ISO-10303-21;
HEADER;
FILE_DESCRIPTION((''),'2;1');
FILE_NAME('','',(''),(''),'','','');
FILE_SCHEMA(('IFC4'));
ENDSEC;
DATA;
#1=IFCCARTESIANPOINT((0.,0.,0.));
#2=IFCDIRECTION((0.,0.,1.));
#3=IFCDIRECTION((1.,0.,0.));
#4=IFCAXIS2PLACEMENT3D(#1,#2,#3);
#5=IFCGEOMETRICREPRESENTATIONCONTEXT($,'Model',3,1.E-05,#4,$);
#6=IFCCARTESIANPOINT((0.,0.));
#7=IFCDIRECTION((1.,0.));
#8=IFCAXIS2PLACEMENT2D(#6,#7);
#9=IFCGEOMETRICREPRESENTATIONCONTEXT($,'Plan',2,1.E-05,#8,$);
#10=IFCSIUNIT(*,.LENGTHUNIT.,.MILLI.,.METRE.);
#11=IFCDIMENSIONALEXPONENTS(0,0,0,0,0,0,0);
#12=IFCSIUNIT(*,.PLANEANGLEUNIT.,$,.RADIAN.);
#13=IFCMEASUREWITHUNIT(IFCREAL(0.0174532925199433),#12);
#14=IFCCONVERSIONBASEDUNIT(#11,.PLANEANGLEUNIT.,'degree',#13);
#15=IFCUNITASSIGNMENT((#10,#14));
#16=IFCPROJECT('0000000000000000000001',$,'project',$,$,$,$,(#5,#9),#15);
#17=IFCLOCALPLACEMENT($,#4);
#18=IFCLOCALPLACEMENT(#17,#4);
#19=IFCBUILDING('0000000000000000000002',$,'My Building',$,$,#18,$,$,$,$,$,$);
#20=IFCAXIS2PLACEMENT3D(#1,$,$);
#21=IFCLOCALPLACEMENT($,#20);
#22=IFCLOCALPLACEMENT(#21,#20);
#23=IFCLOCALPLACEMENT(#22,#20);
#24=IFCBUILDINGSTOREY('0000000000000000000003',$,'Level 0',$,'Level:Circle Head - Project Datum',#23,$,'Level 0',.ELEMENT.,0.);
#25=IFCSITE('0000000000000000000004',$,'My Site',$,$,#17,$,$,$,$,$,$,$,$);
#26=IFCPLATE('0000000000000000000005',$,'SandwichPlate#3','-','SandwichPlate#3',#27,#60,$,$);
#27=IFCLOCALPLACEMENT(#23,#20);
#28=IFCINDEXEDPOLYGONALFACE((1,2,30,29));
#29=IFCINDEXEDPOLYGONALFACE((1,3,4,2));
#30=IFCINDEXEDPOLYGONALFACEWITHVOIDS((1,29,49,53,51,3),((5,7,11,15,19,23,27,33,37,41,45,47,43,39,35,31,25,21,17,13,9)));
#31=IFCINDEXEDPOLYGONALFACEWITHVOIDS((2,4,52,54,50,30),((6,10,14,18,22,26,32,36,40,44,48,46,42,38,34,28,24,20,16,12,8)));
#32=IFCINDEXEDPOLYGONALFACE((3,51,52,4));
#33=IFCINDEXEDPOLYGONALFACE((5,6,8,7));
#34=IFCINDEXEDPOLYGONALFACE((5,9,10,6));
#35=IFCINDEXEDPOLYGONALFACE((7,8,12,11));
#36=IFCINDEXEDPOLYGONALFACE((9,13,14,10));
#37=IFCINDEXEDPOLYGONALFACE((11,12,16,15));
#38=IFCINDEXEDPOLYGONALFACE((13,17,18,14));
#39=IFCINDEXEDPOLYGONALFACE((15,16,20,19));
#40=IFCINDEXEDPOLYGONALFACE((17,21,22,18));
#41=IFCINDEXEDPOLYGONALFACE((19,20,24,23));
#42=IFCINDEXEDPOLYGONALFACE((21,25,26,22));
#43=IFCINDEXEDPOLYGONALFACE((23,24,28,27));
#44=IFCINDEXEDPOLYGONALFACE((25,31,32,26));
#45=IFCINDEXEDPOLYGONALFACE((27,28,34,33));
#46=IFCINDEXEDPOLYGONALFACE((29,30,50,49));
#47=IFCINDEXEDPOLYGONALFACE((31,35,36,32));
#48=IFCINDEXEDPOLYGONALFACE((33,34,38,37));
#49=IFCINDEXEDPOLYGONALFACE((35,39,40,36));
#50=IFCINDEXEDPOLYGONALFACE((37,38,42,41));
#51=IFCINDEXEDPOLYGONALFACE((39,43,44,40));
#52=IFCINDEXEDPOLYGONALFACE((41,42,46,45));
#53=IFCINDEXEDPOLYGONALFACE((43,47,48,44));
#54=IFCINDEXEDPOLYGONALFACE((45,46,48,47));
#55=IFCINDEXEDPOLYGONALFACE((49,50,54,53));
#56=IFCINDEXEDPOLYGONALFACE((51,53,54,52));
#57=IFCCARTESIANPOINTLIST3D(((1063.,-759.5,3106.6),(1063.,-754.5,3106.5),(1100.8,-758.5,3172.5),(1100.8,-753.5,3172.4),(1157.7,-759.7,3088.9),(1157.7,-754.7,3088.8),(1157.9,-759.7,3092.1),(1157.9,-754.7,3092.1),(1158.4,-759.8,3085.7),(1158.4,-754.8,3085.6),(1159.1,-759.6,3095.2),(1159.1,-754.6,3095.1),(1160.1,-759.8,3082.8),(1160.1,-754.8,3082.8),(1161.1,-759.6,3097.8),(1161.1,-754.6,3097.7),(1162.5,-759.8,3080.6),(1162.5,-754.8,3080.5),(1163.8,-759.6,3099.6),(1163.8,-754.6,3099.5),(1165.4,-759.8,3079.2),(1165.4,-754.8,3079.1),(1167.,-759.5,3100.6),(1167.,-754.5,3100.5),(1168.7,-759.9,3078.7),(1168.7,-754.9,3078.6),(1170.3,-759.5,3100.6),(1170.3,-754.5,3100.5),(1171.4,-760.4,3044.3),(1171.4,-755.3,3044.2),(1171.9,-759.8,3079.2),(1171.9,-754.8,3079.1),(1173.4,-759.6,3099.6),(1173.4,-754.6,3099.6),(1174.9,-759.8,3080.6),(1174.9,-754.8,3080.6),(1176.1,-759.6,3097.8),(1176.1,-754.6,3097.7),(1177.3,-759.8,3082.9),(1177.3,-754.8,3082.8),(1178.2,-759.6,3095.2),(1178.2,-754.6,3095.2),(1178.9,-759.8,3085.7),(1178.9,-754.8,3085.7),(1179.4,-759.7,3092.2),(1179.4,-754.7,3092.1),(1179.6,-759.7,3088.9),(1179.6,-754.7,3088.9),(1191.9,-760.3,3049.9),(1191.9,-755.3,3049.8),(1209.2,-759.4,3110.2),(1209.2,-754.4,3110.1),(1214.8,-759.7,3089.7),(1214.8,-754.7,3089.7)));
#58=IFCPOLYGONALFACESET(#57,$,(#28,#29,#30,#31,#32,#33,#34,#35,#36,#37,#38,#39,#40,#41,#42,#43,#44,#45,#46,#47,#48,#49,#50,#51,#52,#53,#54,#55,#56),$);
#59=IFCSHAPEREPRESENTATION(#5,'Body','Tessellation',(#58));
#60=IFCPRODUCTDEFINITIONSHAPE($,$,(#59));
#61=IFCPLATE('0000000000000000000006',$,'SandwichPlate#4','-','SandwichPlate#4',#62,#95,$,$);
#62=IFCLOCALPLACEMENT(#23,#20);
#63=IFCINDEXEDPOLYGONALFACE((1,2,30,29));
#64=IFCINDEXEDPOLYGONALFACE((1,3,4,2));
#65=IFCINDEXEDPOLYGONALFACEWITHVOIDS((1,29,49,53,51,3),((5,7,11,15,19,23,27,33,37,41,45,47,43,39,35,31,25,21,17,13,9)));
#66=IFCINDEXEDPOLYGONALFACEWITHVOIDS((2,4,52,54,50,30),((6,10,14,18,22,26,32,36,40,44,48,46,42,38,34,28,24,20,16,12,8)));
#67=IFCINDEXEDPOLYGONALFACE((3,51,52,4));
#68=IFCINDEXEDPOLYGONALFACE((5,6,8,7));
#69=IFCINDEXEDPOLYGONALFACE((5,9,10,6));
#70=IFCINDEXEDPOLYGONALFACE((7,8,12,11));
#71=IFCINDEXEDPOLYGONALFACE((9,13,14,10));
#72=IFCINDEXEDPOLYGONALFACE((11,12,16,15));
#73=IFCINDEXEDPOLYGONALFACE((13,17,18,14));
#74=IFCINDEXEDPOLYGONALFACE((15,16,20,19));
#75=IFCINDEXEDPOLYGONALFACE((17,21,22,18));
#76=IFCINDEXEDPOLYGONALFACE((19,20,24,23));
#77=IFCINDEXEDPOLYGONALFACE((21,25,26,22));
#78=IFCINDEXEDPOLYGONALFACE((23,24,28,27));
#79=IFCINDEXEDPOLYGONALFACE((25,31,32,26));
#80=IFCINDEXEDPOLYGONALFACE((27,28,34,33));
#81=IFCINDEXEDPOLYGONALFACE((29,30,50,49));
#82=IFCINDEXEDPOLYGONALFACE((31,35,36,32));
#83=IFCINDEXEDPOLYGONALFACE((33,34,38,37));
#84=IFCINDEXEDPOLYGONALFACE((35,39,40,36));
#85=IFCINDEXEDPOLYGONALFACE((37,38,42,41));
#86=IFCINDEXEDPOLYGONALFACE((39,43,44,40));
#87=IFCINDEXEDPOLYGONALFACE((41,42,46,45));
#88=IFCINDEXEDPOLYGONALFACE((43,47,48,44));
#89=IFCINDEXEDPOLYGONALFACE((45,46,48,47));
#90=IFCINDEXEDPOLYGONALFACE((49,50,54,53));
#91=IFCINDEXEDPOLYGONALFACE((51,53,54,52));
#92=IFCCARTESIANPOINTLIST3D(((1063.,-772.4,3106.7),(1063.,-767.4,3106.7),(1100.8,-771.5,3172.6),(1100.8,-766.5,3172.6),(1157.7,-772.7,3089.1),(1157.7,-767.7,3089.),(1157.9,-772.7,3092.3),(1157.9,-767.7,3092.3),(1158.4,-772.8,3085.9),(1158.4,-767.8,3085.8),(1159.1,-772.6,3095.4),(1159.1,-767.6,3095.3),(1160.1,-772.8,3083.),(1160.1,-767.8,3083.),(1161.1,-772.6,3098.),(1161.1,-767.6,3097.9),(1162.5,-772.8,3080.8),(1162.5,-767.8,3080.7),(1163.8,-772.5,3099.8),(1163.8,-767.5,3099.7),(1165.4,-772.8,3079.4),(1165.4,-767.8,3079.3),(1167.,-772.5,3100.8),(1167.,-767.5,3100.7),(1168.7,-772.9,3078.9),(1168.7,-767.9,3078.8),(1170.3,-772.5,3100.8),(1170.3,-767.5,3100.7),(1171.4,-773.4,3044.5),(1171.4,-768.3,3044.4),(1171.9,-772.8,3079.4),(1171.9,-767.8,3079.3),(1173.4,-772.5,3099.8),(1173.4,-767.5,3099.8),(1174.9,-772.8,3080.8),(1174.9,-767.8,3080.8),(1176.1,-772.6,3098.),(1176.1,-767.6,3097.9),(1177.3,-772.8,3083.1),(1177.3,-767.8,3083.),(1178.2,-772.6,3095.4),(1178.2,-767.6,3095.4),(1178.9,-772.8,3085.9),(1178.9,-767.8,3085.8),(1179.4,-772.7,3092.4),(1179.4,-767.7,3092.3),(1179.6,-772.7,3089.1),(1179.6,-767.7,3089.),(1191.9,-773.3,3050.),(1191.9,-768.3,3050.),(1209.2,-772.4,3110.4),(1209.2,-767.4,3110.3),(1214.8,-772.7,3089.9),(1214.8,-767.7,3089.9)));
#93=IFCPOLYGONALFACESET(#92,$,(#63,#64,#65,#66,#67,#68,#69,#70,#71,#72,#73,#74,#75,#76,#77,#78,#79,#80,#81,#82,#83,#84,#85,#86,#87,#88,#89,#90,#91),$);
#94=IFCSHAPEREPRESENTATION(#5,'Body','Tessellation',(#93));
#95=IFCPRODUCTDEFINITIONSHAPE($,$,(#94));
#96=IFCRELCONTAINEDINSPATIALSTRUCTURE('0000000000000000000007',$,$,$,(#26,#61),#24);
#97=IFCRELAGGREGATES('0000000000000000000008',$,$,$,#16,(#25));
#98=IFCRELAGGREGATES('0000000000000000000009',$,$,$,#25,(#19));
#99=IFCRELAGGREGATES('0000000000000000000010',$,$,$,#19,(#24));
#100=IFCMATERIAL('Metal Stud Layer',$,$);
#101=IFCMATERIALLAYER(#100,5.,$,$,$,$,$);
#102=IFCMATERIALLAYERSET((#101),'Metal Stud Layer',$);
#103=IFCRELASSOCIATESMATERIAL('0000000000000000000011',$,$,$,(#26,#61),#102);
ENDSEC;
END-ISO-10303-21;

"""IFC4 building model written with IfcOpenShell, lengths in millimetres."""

from ifc_helpers import new_model, entity, si_unit, converted_unit, frame, origin, origin_with_axes, origin_2d_with_axis, place, context, project, spatial, polyline, circle, outline, extrude, material, layer, layer_set, element, save


model = new_model("IFC4")

# Units and contexts
model_context = context("Model", 3, precision=1e-05, world=origin_with_axes())
plan_context = context("Plan", 2, precision=1e-05, world=origin_2d_with_axis())
ifc_project = project(units=[si_unit("LENGTHUNIT", "METRE", prefix="MILLI"), converted_unit("PLANEANGLEUNIT", "degree", entity("IfcReal", 0.0174532925199433), si_unit("PLANEANGLEUNIT", "RADIAN"), dimensions=[0, 0, 0, 0, 0, 0, 0])], contexts=[model_context, plan_context])

# Site, building, storey
site_placement = place(None, origin_with_axes())
site = spatial("IfcSite", under=ifc_project, at=site_placement, Name="My Site")
building_placement = place(site_placement, origin_with_axes())
building = spatial("IfcBuilding", under=site, at=building_placement, Name="My Building")
placement_1 = place(None, origin())
placement_2 = place(placement_1, origin())
storey_placement = place(placement_2, origin())
storey = spatial("IfcBuildingStorey", under=building, at=storey_placement, Name="Level 0", ObjectType="Level:Circle Head - Project Datum", LongName="Level 0", CompositionType="ELEMENT", Elevation=0.0)

# Plates, openings
ifc_material = material(Name="Metal Stud Layer")
ifc_layer_1 = layer(ifc_material, 5.0)
ifc_layer_set_1 = layer_set([ifc_layer_1], Name="Metal Stud Layer")
plate_1_placement = place(storey_placement, frame((1184.4, -755.5, 3036.8), z_axis=(0.0, -0.999896, 0.014432), x_axis=(0.497964, 0.012516, 0.867107)))
plate_1 = element("IfcPlate", 1, at=plate_1_placement, inside=storey, material=ifc_layer_set_1, Name="SandwichPlate#3", Description="-", ObjectType="SandwichPlate#3", context=model_context, shape_type="SweptSolid", body=[
    extrude(outline(polyline([(0.0, 0.0), (76.0, 0.0), (76.0, 140.0), (0.0, 140.0), (0.0, 0.0)])), origin_with_axes(), (0.0, 0.0, 1.0), 5.0),
])
opening_1_placement = place(plate_1_placement, frame((38.0, 40.0, -0.5), z_axis=(0.0, 0.0, 1.0), x_axis=(0.0, 1.0, 0.0)))
element("IfcOpeningElement", 2, at=opening_1_placement, cuts=plate_1, ObjectType="Opening", context=model_context, shape_type="SweptSolid", body=[
    extrude(circle(Radius=11.0, at=origin_2d_with_axis()), origin(), (0.0, 0.0, 1.0), 6.0),
])
opening_2_placement = place(plate_1_placement, frame((0.0, 0.0, 0.0), z_axis=(0.0, 0.0, 1.0), x_axis=(1.0, 0.0, 0.0)))
element("IfcOpeningElement", 3, at=opening_2_placement, cuts=plate_1, ObjectType="Opening", context=model_context, shape_type="SweptSolid", body=[
    extrude(outline(polyline([(0.0, 0.0), (15.0, 0.0), (0.0, 15.0), (0.0, 0.0)])), origin(), (0.0, 0.0, 1.0), 5.0),
])
opening_3_placement = place(plate_1_placement, frame((0.0, 0.0, 0.0), z_axis=(0.0, 0.0, 1.0), x_axis=(1.0, 0.0, 0.0)))
element("IfcOpeningElement", 4, at=opening_3_placement, cuts=plate_1, ObjectType="Opening", context=model_context, shape_type="SweptSolid", body=[
    extrude(outline(polyline([(76.0, 0.0), (76.0, 15.0), (61.0, 0.0), (76.0, 0.0)])), origin(), (0.0, 0.0, 1.0), 5.0),
])
plate_2_placement = place(storey_placement, frame((1184.4, -768.5, 3037.0), z_axis=(0.0, -0.999896, 0.014432), x_axis=(0.497964, 0.012516, 0.867107)))
plate_2 = element("IfcPlate", 5, at=plate_2_placement, inside=storey, material=ifc_layer_set_1, Name="SandwichPlate#4", Description="-", ObjectType="SandwichPlate#4", context=model_context, shape_type="SweptSolid", body=[
    extrude(outline(polyline([(0.0, 0.0), (76.0, 0.0), (76.0, 140.0), (0.0, 140.0), (0.0, 0.0)])), origin_with_axes(), (0.0, 0.0, 1.0), 5.0),
])
opening_4_placement = place(plate_2_placement, frame((38.0, 40.0, -0.5), z_axis=(0.0, 0.0, 1.0), x_axis=(0.0, 1.0, 0.0)))
element("IfcOpeningElement", 6, at=opening_4_placement, cuts=plate_2, ObjectType="Opening", context=model_context, shape_type="SweptSolid", body=[
    extrude(circle(Radius=11.0, at=origin_2d_with_axis()), origin(), (0.0, 0.0, 1.0), 6.0),
])
opening_5_placement = place(plate_2_placement, frame((0.0, 0.0, 0.0), z_axis=(0.0, 0.0, 1.0), x_axis=(1.0, 0.0, 0.0)))
element("IfcOpeningElement", 7, at=opening_5_placement, cuts=plate_2, ObjectType="Opening", context=model_context, shape_type="SweptSolid", body=[
    extrude(outline(polyline([(0.0, 0.0), (15.0, 0.0), (0.0, 15.0), (0.0, 0.0)])), origin(), (0.0, 0.0, 1.0), 5.0),
])
opening_6_placement = place(plate_2_placement, frame((0.0, 0.0, 0.0), z_axis=(0.0, 0.0, 1.0), x_axis=(1.0, 0.0, 0.0)))
element("IfcOpeningElement", 8, at=opening_6_placement, cuts=plate_2, ObjectType="Opening", context=model_context, shape_type="SweptSolid", body=[
    extrude(outline(polyline([(76.0, 0.0), (76.0, 15.0), (61.0, 0.0), (76.0, 0.0)])), origin(), (0.0, 0.0, 1.0), 5.0),
])

save(model, "model.ifc")
